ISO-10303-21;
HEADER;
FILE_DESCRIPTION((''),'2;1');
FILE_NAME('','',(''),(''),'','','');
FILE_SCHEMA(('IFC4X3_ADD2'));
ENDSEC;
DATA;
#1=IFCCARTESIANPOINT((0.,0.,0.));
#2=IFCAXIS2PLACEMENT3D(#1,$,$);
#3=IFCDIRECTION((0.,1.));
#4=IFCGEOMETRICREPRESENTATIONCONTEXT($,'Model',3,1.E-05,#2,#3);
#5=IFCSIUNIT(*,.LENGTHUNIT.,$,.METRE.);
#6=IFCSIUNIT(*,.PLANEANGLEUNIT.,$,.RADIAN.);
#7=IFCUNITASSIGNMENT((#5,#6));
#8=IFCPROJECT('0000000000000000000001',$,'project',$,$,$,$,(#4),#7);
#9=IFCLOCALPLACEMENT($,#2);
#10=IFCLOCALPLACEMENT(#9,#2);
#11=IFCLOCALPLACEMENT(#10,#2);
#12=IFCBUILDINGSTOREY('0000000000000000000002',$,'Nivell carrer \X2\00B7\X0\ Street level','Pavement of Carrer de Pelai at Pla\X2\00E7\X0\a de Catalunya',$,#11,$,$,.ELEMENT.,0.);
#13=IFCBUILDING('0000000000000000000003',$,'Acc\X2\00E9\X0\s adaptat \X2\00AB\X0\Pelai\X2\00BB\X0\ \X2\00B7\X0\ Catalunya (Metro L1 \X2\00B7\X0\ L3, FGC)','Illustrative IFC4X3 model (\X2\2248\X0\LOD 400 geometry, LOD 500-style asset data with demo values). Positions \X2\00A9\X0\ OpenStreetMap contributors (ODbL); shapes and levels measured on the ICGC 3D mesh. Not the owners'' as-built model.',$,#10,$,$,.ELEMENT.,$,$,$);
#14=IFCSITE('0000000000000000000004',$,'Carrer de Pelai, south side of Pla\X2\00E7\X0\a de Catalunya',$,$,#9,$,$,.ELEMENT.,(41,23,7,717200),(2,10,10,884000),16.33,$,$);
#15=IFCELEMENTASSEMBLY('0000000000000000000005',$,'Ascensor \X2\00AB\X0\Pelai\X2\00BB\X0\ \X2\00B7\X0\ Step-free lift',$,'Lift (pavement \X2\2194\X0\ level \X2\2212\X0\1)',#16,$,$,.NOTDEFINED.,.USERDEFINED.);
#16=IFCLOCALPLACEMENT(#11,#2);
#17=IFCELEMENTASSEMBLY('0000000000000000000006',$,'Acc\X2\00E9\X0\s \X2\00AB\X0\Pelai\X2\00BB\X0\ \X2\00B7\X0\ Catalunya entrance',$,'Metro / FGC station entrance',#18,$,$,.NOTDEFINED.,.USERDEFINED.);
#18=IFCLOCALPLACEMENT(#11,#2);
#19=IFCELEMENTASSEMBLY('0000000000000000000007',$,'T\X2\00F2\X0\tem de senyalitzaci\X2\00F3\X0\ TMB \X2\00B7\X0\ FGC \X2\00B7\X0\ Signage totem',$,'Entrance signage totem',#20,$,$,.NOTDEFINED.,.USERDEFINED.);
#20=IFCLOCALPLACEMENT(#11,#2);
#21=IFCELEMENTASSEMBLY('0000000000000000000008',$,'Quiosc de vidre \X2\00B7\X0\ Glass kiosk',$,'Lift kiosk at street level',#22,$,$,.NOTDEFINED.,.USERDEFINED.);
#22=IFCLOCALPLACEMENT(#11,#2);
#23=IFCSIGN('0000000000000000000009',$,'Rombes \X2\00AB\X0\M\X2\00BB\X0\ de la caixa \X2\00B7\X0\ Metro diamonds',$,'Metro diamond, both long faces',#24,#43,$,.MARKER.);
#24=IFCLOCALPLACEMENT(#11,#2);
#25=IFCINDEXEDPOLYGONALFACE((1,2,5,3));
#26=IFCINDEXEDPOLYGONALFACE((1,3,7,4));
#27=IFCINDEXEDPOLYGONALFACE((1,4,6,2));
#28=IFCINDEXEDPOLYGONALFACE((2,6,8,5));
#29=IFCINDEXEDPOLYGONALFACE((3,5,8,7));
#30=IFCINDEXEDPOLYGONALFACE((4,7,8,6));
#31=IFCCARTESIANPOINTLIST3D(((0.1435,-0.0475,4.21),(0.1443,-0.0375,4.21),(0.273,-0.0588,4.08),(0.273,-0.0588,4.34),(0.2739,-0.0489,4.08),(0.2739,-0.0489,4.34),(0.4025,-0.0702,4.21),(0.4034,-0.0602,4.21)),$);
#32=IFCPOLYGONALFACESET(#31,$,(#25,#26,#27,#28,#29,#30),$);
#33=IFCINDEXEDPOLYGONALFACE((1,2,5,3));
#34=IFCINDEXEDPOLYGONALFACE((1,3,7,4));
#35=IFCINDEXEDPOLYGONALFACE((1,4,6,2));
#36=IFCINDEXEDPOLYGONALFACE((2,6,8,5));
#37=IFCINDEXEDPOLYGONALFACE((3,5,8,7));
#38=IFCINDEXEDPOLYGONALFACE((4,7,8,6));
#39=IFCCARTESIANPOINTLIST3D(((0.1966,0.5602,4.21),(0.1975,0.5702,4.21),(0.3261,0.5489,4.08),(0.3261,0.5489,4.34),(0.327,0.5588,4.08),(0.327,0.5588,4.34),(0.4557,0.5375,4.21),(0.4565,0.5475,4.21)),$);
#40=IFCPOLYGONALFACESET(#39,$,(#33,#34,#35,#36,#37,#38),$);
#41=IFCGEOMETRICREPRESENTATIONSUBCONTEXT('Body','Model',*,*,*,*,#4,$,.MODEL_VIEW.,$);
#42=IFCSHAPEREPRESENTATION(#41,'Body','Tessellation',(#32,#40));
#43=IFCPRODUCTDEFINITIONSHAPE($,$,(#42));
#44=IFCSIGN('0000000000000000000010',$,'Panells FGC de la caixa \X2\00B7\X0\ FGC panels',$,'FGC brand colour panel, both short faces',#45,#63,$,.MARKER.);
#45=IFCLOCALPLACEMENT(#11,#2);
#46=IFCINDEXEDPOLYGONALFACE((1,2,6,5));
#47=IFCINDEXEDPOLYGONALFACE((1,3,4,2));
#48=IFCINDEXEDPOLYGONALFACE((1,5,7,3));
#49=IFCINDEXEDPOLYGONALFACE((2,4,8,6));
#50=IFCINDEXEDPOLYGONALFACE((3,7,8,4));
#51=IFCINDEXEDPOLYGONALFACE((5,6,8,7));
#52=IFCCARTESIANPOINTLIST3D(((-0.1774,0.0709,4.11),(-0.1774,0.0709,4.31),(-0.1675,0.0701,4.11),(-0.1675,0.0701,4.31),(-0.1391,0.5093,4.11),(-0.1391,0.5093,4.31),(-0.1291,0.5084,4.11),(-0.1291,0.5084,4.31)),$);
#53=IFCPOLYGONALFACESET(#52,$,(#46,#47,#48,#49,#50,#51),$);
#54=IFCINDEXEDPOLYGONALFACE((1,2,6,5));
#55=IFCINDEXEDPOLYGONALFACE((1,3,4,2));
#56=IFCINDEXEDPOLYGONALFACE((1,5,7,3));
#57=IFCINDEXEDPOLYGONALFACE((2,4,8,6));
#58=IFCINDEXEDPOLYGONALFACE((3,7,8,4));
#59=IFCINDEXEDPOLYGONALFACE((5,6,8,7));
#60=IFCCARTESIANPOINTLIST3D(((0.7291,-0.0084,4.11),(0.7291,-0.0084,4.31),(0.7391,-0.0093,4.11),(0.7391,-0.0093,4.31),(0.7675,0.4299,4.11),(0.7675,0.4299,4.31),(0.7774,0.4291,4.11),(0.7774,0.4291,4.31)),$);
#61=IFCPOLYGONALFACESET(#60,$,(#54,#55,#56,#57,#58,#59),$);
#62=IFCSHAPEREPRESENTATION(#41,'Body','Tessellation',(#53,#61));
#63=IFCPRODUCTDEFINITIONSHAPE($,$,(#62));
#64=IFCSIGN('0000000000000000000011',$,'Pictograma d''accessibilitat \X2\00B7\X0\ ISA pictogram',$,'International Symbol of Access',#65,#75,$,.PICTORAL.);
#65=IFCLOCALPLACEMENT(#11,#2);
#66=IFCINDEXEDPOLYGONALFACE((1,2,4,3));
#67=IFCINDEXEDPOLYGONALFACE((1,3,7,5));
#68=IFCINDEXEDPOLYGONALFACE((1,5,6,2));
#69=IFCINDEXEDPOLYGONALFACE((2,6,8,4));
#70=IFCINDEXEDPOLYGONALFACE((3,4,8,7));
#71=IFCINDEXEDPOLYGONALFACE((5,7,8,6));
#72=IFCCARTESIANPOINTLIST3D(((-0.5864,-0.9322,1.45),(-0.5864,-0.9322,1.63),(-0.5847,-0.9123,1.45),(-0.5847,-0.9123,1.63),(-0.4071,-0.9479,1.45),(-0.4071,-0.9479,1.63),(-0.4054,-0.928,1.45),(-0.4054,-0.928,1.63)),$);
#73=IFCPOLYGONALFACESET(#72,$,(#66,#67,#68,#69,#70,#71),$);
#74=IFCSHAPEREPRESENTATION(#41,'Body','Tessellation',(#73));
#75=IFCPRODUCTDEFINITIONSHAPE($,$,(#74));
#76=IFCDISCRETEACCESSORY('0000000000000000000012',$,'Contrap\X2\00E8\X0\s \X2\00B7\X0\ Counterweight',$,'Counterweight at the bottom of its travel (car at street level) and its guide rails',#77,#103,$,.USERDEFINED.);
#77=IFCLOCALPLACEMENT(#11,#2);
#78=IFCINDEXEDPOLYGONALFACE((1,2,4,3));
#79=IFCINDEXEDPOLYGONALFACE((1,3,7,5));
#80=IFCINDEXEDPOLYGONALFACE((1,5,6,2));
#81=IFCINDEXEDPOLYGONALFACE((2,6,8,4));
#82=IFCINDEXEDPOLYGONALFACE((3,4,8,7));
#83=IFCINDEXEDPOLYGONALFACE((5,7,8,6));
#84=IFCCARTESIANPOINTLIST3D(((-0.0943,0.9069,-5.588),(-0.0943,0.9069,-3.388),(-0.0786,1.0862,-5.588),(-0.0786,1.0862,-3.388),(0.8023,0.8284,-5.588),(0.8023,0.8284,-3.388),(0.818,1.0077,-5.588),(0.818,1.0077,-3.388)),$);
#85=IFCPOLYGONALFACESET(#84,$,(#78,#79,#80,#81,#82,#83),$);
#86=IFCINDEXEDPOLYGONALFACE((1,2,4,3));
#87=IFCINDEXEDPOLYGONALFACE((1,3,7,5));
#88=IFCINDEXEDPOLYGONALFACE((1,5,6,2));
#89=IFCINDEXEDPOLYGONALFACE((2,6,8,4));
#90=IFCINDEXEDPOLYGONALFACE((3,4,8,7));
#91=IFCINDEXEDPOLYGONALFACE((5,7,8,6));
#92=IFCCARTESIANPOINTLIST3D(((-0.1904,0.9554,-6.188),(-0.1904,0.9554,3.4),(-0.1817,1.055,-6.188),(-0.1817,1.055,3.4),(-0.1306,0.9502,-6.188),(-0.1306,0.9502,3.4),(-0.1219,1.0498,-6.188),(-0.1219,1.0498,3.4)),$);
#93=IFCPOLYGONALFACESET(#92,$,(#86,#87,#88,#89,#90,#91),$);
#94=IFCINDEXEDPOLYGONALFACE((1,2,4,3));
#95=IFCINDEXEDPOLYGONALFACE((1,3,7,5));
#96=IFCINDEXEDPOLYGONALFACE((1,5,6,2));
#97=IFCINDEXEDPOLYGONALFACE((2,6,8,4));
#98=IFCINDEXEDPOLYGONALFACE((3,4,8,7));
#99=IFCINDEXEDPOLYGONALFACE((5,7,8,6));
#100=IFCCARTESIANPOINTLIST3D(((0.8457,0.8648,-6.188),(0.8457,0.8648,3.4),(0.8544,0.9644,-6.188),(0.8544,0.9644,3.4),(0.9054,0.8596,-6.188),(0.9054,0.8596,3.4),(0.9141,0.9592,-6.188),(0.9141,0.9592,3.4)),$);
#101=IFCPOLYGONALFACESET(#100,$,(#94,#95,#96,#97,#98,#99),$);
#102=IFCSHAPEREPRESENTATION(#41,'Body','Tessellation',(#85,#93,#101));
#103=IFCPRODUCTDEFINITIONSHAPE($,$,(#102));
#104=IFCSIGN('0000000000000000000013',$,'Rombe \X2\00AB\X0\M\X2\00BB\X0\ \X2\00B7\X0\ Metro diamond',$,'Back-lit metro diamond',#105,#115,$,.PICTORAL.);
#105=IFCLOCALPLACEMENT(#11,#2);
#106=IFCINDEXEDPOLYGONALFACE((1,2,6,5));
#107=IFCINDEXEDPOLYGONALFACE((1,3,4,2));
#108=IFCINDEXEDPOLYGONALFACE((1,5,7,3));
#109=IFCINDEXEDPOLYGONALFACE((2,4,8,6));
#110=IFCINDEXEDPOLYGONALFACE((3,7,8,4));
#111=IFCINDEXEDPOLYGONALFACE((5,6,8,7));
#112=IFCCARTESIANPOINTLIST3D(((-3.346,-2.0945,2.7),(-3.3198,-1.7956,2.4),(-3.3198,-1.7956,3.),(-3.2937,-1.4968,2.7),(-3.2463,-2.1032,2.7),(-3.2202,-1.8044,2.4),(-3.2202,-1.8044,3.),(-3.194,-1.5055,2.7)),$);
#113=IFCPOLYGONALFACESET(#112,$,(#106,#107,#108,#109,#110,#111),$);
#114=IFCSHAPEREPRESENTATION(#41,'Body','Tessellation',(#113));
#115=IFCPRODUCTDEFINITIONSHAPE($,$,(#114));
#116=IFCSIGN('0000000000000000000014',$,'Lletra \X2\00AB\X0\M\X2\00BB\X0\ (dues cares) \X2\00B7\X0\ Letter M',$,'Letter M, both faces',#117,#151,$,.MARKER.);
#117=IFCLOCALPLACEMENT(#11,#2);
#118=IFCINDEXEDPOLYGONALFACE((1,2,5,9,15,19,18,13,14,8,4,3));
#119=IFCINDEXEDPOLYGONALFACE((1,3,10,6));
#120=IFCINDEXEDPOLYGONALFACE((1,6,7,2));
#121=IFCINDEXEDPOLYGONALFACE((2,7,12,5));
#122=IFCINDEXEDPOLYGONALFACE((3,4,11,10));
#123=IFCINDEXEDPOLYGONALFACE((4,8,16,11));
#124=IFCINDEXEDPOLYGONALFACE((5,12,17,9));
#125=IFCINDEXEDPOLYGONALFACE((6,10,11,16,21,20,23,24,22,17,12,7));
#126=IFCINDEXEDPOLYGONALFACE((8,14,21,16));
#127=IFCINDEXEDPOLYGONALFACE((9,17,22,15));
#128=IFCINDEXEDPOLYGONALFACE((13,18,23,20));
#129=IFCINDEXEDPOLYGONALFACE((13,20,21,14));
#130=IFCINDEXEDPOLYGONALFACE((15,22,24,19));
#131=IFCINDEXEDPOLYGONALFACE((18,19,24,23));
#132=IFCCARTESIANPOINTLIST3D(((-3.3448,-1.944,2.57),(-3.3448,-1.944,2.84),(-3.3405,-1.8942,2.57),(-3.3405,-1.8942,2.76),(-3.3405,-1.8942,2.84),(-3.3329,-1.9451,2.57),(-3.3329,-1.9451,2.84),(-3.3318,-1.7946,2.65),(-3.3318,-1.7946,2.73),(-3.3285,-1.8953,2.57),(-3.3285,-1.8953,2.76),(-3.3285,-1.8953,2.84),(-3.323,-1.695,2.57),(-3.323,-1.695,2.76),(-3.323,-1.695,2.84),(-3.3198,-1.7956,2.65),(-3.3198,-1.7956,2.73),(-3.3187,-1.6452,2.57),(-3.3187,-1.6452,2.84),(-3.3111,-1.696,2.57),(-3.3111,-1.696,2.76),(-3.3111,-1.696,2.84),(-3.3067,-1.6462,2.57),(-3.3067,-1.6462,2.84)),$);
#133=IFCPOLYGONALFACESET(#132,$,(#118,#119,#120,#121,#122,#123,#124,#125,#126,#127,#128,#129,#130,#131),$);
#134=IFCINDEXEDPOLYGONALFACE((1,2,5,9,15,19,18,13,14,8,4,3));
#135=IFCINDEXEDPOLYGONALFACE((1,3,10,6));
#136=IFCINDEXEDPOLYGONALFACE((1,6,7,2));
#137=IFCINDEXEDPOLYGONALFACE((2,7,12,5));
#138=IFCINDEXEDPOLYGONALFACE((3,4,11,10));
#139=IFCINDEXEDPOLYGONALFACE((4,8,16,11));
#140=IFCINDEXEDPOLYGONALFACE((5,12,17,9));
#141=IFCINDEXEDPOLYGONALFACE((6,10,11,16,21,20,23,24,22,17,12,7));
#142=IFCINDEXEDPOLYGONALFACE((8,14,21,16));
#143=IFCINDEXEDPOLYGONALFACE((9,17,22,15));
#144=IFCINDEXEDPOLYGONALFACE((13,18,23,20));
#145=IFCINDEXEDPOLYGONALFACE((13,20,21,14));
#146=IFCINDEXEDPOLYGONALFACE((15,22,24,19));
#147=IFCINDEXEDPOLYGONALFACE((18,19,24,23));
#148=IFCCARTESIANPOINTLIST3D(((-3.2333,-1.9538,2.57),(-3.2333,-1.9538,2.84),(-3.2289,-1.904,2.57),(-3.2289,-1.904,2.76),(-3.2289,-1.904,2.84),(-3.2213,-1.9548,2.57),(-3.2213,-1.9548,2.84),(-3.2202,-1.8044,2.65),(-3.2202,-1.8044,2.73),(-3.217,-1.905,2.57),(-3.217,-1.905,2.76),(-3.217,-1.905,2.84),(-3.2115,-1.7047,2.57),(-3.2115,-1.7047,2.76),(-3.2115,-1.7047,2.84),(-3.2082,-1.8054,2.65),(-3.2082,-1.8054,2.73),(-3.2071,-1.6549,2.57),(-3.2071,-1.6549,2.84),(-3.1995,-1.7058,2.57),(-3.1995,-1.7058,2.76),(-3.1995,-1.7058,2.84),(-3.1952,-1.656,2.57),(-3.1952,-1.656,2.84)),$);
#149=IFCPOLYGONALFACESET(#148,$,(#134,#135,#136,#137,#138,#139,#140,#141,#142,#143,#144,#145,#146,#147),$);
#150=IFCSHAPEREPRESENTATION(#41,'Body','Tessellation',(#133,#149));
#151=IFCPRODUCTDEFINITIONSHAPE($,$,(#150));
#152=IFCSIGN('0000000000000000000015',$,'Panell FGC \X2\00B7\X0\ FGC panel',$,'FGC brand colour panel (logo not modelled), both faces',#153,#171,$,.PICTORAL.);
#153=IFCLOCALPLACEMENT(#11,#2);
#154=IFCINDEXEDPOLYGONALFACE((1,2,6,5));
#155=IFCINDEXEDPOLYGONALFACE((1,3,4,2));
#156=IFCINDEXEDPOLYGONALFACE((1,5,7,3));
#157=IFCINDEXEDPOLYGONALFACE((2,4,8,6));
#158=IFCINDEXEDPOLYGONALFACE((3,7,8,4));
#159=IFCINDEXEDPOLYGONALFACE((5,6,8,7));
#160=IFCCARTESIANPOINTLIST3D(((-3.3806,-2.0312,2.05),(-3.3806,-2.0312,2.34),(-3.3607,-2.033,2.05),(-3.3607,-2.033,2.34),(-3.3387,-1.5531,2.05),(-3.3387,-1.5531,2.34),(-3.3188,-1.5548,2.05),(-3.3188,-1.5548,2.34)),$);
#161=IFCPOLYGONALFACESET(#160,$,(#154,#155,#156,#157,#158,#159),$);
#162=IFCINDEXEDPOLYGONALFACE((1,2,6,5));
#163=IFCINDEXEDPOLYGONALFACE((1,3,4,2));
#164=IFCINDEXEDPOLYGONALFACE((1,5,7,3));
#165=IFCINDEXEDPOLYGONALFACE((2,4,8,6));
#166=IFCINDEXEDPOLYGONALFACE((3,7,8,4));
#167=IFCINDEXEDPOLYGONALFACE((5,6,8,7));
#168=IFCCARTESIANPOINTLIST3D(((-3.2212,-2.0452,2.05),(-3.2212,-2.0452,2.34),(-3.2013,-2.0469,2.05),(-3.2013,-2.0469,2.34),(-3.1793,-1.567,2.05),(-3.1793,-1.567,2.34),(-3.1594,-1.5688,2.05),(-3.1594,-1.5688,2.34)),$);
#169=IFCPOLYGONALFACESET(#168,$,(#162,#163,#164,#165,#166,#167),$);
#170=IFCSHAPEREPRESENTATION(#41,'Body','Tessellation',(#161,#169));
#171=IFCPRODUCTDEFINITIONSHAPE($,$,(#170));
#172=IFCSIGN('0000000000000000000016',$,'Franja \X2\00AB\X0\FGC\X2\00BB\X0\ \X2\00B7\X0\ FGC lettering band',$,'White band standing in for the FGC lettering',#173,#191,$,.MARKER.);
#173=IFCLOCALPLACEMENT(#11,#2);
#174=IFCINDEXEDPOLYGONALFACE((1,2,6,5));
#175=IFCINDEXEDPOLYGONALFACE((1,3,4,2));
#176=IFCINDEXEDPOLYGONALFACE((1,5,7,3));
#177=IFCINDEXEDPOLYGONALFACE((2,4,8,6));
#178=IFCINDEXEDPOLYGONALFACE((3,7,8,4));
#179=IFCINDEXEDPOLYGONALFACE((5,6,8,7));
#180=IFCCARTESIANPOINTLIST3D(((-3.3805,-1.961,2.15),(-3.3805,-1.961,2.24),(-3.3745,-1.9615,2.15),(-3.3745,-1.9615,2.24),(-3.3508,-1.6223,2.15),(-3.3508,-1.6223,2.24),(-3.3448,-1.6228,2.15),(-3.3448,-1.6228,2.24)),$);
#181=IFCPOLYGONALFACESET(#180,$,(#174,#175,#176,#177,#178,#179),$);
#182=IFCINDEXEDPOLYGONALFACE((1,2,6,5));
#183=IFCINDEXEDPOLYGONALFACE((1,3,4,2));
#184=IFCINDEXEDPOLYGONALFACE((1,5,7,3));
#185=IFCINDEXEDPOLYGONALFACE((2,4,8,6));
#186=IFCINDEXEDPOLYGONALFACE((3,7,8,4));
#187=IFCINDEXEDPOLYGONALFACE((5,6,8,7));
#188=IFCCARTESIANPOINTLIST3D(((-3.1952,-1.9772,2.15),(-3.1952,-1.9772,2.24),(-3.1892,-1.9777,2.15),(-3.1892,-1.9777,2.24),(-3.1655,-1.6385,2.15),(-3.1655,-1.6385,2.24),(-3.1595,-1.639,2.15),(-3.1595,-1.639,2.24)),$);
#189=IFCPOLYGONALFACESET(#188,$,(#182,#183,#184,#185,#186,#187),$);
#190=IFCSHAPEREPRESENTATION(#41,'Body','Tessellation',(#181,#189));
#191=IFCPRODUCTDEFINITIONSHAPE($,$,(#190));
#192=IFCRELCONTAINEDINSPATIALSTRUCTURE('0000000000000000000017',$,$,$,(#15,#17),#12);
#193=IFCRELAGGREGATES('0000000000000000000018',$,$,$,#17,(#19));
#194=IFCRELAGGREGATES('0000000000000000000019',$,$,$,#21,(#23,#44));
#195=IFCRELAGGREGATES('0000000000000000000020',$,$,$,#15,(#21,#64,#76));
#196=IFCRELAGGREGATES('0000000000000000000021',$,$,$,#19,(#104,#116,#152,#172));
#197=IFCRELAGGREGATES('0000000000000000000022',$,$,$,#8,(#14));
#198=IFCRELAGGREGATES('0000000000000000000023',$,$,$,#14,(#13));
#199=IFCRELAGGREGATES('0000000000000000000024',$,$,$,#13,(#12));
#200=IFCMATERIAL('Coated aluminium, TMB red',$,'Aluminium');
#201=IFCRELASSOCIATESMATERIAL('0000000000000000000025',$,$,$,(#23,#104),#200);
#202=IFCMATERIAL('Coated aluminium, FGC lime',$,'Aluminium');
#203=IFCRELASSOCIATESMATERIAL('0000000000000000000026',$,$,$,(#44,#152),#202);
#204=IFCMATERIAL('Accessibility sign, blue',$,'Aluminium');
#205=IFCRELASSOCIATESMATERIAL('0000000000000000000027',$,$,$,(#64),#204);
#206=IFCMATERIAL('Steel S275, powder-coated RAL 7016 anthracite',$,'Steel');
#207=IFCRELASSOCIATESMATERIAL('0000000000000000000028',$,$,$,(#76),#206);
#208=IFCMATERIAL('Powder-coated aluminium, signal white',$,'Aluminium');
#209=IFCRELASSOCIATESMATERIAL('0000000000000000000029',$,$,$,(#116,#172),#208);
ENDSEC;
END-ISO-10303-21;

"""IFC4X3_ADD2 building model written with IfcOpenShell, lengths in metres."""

from ifc_helpers import new_model, si_unit, direction, frame, frame_2d, origin, place, context, subcontext, project, spatial, polyline, rectangle, outline, extrude, material, element, aggregate, save


model = new_model("IFC4X3_ADD2")

# Units and contexts
model_context = context("Model", 3, precision=1e-05, world=origin(), true_north=direction((0.0, 1.0)))
body_context = subcontext(model_context, "Body", "Model", "MODEL_VIEW")
ifc_project = project(units=[si_unit("LENGTHUNIT", "METRE"), si_unit("PLANEANGLEUNIT", "RADIAN")], contexts=[model_context])

# Site, building, storey
site_placement = place(None, origin())
site = spatial("IfcSite", under=ifc_project, at=site_placement, Name="Carrer de Pelai, south side of Plaça de Catalunya", CompositionType="ELEMENT", RefLatitude=(41, 23, 7, 717200), RefLongitude=(2, 10, 10, 884000), RefElevation=16.33)
building_placement = place(site_placement, origin())
building = spatial("IfcBuilding", under=site, at=building_placement, Name="Accés adaptat «Pelai» · Catalunya (Metro L1 · L3, FGC)", Description="Illustrative IFC4X3 model (≈LOD 400 geometry, LOD 500-style asset data with demo values). Positions © OpenStreetMap contributors (ODbL); shapes and levels measured on the ICGC 3D mesh. Not the owners' as-built model.", CompositionType="ELEMENT")
storey_placement = place(building_placement, origin())
storey = spatial("IfcBuildingStorey", under=building, at=storey_placement, Name="Nivell carrer · Street level", Description="Pavement of Carrer de Pelai at Plaça de Catalunya", CompositionType="ELEMENT", Elevation=0.0)

# Element assembly
assembly_1_placement = place(building_placement, origin())
assembly_1 = element("IfcElementAssembly", 1, at=assembly_1_placement, inside=storey, Name="Ascensor «Pelai» · Step-free lift", ObjectType="Lift (pavement ↔ level −1)", AssemblyPlace="NOTDEFINED", PredefinedType="USERDEFINED")
ifc_material_1 = material(Name="Steel S275, powder-coated RAL 7016 anthracite", Category="Steel")

# Element assemblies
assembly_2_placement = place(building_placement, origin())
assembly_2 = element("IfcElementAssembly", 2, at=assembly_2_placement, inside=storey, Name="Accés «Pelai» · Catalunya entrance", ObjectType="Metro / FGC station entrance", AssemblyPlace="NOTDEFINED", PredefinedType="USERDEFINED")
assembly_3_placement = place(building_placement, origin())
assembly_3 = element("IfcElementAssembly", 3, at=assembly_3_placement, Name="Tòtem de senyalització TMB · FGC · Signage totem", ObjectType="Entrance signage totem", AssemblyPlace="NOTDEFINED", PredefinedType="USERDEFINED")
aggregate(assembly_2, [assembly_3])

# Element assembly
assembly_4_placement = place(building_placement, origin())
assembly_4 = element("IfcElementAssembly", 4, at=assembly_4_placement, Name="Quiosc de vidre · Glass kiosk", ObjectType="Lift kiosk at street level", AssemblyPlace="NOTDEFINED", PredefinedType="USERDEFINED")

# Signs
ifc_material_2 = material(Name="Powder-coated aluminium, signal white", Category="Aluminium")
ifc_material_3 = material(Name="Coated aluminium, TMB red", Category="Aluminium")
sign_1_placement = place(building_placement, origin())
sign_1 = element("IfcSign", 5, at=sign_1_placement, material=ifc_material_3, Name="Rombes «M» de la caixa · Metro diamonds", ObjectType="Metro diamond, both long faces", PredefinedType="MARKER", context=body_context, shape_type="SweptSolid", body=[
    extrude(outline(polyline([(-0.13, 4.21), (0.0, 4.08), (0.13, 4.21), (0.0, 4.34), (-0.13, 4.21)])), frame((0.2739, -0.0489, 0.0), z_axis=(-0.087156, -0.996195, 0.0), x_axis=(0.996195, -0.087156, 0.0)), (0.0, 0.0, 1.0), 0.01),
    extrude(outline(polyline([(-0.13, 4.21), (0.0, 4.08), (0.13, 4.21), (0.0, 4.34), (-0.13, 4.21)])), frame((0.327, 0.5588, 0.0), z_axis=(-0.087156, -0.996195, 0.0), x_axis=(0.996195, -0.087156, 0.0)), (0.0, 0.0, 1.0), 0.01),
])
ifc_material_4 = material(Name="Coated aluminium, FGC lime", Category="Aluminium")
sign_2_placement = place(building_placement, origin())
sign_2 = element("IfcSign", 6, at=sign_2_placement, material=ifc_material_4, Name="Panells FGC de la caixa · FGC panels", ObjectType="FGC brand colour panel, both short faces", PredefinedType="MARKER", context=body_context, shape_type="SweptSolid", body=[
    extrude(outline(polyline([(-0.22, 4.11), (0.22, 4.11), (0.22, 4.31), (-0.22, 4.31), (-0.22, 4.11)])), frame((-0.1582, 0.2901, 0.0), z_axis=(0.996195, -0.087156, 0.0), x_axis=(0.087156, 0.996195, 0.0)), (0.0, 0.0, 1.0), 0.01),
    extrude(outline(polyline([(-0.22, 4.11), (0.22, 4.11), (0.22, 4.31), (-0.22, 4.31), (-0.22, 4.11)])), frame((0.7483, 0.2108, 0.0), z_axis=(0.996195, -0.087156, 0.0), x_axis=(0.087156, 0.996195, 0.0)), (0.0, 0.0, 1.0), 0.01),
])
aggregate(assembly_4, [sign_1, sign_2])
ifc_material_5 = material(Name="Accessibility sign, blue", Category="Aluminium")
sign_3_placement = place(building_placement, origin())
sign_3 = element("IfcSign", 7, at=sign_3_placement, material=ifc_material_5, Name="Pictograma d'accessibilitat · ISA pictogram", ObjectType="International Symbol of Access", PredefinedType="PICTORAL", context=body_context, shape_type="SweptSolid", body=[
    extrude(rectangle(XDim=0.18, YDim=0.02, at=frame_2d((0.0, 0.0), x_axis=(0.996195, -0.087156))), frame((-0.4959, -0.9301, 1.45)), (0.0, 0.0, 1.0), 0.18),
])

# Discrete accessory
discrete_accessory_1_placement = place(building_placement, origin())
discrete_accessory_1 = element("IfcDiscreteAccessory", 8, at=discrete_accessory_1_placement, material=ifc_material_1, Name="Contrapès · Counterweight", ObjectType="Counterweight at the bottom of its travel (car at street level) and its guide rails", PredefinedType="USERDEFINED", context=body_context, shape_type="SweptSolid", body=[
    extrude(rectangle(XDim=0.9, YDim=0.18, at=frame_2d((0.0, 0.0), x_axis=(0.996195, -0.087156))), frame((0.3619, 0.9573, -5.588)), (0.0, 0.0, 1.0), 2.2),
    extrude(rectangle(XDim=0.06, YDim=0.1, at=frame_2d((0.0, 0.0), x_axis=(0.996195, -0.087156))), frame((-0.1561, 1.0026, -6.188)), (0.0, 0.0, 1.0), 9.588),
    extrude(rectangle(XDim=0.06, YDim=0.1, at=frame_2d((0.0, 0.0), x_axis=(0.996195, -0.087156))), frame((0.8799, 0.912, -6.188)), (0.0, 0.0, 1.0), 9.588),
])
aggregate(assembly_1, [assembly_4, sign_3, discrete_accessory_1])

# Signs
sign_4_placement = place(building_placement, origin())
sign_4 = element("IfcSign", 9, at=sign_4_placement, material=ifc_material_3, Name="Rombe «M» · Metro diamond", ObjectType="Back-lit metro diamond", PredefinedType="PICTORAL", context=body_context, shape_type="SweptSolid", body=[
    extrude(outline(polyline([(-0.3, 2.7), (0.0, 2.4), (0.3, 2.7), (0.0, 3.0), (-0.3, 2.7)])), frame((-3.3198, -1.7956, 0.0), z_axis=(0.996195, -0.087156, 0.0), x_axis=(0.087156, 0.996195, 0.0)), (0.0, 0.0, 1.0), 0.1),
])
sign_5_placement = place(building_placement, origin())
sign_5 = element("IfcSign", 10, at=sign_5_placement, material=ifc_material_2, Name="Lletra «M» (dues cares) · Letter M", ObjectType="Letter M, both faces", PredefinedType="MARKER", context=body_context, shape_type="SweptSolid", body=[
    extrude(outline(polyline([(-0.15, 2.57), (-0.1, 2.57), (-0.1, 2.76), (0.0, 2.65), (0.1, 2.76), (0.1, 2.57), (0.15, 2.57), (0.15, 2.84), (0.1, 2.84), (0.0, 2.73), (-0.1, 2.84), (-0.15, 2.84), (-0.15, 2.57)])), frame((-3.3318, -1.7946, 0.0), z_axis=(0.996195, -0.087156, 0.0), x_axis=(0.087156, 0.996195, 0.0)), (0.0, 0.0, 1.0), 0.012),
    extrude(outline(polyline([(-0.15, 2.57), (-0.1, 2.57), (-0.1, 2.76), (0.0, 2.65), (0.1, 2.76), (0.1, 2.57), (0.15, 2.57), (0.15, 2.84), (0.1, 2.84), (0.0, 2.73), (-0.1, 2.84), (-0.15, 2.84), (-0.15, 2.57)])), frame((-3.2202, -1.8044, 0.0), z_axis=(0.996195, -0.087156, 0.0), x_axis=(0.087156, 0.996195, 0.0)), (0.0, 0.0, 1.0), 0.012),
])
sign_6_placement = place(building_placement, origin())
sign_6 = element("IfcSign", 11, at=sign_6_placement, material=ifc_material_4, Name="Panell FGC · FGC panel", ObjectType="FGC brand colour panel (logo not modelled), both faces", PredefinedType="PICTORAL", context=body_context, shape_type="SweptSolid", body=[
    extrude(outline(polyline([(-0.24, 2.05), (0.24, 2.05), (0.24, 2.34), (-0.24, 2.34), (-0.24, 2.05)])), frame((-3.3597, -1.7922, 0.0), z_axis=(0.996195, -0.087156, 0.0), x_axis=(0.087156, 0.996195, 0.0)), (0.0, 0.0, 1.0), 0.02),
    extrude(outline(polyline([(-0.24, 2.05), (0.24, 2.05), (0.24, 2.34), (-0.24, 2.34), (-0.24, 2.05)])), frame((-3.2003, -1.8061, 0.0), z_axis=(0.996195, -0.087156, 0.0), x_axis=(0.087156, 0.996195, 0.0)), (0.0, 0.0, 1.0), 0.02),
])
sign_7_placement = place(building_placement, origin())
sign_7 = element("IfcSign", 12, at=sign_7_placement, material=ifc_material_2, Name="Franja «FGC» · FGC lettering band", ObjectType="White band standing in for the FGC lettering", PredefinedType="MARKER", context=body_context, shape_type="SweptSolid", body=[
    extrude(outline(polyline([(-0.17, 2.15), (0.17, 2.15), (0.17, 2.24), (-0.17, 2.24), (-0.17, 2.15)])), frame((-3.3656, -1.7916, 0.0), z_axis=(0.996195, -0.087156, 0.0), x_axis=(0.087156, 0.996195, 0.0)), (0.0, 0.0, 1.0), 0.006),
    extrude(outline(polyline([(-0.17, 2.15), (0.17, 2.15), (0.17, 2.24), (-0.17, 2.24), (-0.17, 2.15)])), frame((-3.1803, -1.8078, 0.0), z_axis=(0.996195, -0.087156, 0.0), x_axis=(0.087156, 0.996195, 0.0)), (0.0, 0.0, 1.0), 0.006),
])
aggregate(assembly_3, [sign_4, sign_5, sign_6, sign_7])

save(model, "model.ifc")
